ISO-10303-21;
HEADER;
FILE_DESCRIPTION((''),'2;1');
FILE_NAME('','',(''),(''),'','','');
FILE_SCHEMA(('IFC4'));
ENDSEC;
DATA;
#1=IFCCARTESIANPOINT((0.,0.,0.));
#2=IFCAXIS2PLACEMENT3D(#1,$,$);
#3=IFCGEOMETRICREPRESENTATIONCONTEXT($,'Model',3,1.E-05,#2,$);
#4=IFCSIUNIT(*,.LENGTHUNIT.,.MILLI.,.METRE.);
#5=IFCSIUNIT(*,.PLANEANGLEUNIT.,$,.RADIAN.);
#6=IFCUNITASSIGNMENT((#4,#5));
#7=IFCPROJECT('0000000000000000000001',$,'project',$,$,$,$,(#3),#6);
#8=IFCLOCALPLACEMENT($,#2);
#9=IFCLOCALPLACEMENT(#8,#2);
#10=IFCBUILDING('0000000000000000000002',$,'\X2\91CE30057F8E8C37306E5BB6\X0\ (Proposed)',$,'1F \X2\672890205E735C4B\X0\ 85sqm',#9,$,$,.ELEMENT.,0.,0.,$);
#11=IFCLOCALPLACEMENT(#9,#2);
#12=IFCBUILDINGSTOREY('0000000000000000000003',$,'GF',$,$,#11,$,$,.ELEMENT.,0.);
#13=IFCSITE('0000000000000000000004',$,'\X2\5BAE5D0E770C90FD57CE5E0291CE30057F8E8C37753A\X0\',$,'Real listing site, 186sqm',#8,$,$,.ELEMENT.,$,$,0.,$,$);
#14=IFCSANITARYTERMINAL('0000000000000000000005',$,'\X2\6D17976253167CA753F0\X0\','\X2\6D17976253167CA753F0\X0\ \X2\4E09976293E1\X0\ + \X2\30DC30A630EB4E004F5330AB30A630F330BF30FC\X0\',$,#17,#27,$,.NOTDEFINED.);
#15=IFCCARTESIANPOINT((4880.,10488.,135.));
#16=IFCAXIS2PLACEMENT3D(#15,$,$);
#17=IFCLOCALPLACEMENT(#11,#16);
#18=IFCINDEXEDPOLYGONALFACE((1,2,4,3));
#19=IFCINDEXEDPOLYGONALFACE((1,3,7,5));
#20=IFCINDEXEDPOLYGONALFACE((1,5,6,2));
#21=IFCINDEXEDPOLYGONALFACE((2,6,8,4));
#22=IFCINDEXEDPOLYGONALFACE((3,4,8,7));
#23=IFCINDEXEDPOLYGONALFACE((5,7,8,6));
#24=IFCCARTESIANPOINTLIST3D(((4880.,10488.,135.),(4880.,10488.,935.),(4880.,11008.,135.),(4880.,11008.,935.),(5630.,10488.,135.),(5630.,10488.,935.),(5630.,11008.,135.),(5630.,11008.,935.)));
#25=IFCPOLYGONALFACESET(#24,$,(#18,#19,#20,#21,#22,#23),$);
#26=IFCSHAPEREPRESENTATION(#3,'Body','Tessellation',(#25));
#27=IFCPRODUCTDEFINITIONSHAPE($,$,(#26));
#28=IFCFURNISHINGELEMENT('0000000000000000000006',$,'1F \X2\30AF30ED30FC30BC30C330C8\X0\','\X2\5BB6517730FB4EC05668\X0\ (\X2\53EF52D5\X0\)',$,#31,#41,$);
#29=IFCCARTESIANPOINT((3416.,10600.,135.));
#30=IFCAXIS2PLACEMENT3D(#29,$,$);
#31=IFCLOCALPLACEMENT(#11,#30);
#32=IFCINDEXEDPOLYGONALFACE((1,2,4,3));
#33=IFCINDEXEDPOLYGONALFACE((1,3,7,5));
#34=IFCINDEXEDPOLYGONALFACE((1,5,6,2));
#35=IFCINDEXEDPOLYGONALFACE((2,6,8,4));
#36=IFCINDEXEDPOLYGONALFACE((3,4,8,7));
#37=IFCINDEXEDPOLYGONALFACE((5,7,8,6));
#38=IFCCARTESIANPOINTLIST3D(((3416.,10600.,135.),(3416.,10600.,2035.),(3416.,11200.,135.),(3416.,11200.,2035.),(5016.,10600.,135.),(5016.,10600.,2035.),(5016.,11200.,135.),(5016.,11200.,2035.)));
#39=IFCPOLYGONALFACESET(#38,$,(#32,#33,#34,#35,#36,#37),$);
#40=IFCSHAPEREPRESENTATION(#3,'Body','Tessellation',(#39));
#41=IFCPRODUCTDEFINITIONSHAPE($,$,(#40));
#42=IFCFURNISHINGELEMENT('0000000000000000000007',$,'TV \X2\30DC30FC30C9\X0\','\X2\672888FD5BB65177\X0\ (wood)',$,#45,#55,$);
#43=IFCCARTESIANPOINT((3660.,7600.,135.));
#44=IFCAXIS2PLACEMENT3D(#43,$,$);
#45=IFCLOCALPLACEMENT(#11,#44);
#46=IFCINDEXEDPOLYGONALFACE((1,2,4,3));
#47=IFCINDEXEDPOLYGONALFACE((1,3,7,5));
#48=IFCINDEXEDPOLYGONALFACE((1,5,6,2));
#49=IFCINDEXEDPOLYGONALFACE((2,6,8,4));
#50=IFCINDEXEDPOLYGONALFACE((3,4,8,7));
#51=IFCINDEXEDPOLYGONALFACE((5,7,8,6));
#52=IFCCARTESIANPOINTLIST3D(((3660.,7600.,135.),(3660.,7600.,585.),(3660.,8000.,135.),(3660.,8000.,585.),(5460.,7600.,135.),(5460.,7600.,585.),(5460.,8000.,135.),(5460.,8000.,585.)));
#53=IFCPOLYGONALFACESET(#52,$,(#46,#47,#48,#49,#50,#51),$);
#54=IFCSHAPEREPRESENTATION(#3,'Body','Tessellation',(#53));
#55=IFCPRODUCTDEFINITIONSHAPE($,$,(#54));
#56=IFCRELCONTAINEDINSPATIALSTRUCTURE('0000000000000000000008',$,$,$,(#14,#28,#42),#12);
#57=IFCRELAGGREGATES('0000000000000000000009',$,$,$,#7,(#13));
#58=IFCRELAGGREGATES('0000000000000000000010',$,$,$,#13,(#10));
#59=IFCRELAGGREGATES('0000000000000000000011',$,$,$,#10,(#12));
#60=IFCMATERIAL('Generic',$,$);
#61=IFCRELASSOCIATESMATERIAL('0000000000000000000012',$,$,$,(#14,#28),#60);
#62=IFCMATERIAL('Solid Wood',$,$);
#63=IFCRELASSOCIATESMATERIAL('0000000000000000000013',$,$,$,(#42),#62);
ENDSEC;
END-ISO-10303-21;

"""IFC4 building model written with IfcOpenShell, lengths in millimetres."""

from ifc_helpers import new_model, si_unit, frame, frame_2d, origin, place, context, project, spatial, rectangle, extrude, material, element, save


model = new_model("IFC4")

# Units and contexts
model_context = context("Model", 3, precision=1e-05, world=origin())
ifc_project = project(units=[si_unit("LENGTHUNIT", "METRE", prefix="MILLI"), si_unit("PLANEANGLEUNIT", "RADIAN")], contexts=[model_context])

# Site, building, storey
site_placement = place(None, origin())
site = spatial("IfcSite", under=ifc_project, at=site_placement, Name="宮崎県都城市野々美谷町", ObjectType="Real listing site, 186sqm", CompositionType="ELEMENT", RefElevation=0.0)
building_placement = place(site_placement, origin())
building = spatial("IfcBuilding", under=site, at=building_placement, Name="野々美谷の家 (Proposed)", ObjectType="1F 木造平屋 85sqm", CompositionType="ELEMENT", ElevationOfRefHeight=0.0, ElevationOfTerrain=0.0)
storey_placement = place(building_placement, origin())
storey = spatial("IfcBuildingStorey", under=building, at=storey_placement, Name="GF", CompositionType="ELEMENT", Elevation=0.0)

# Shared definitions
ifc_material_1 = material(Name="Solid Wood")

# Shared definitions
ifc_material_2 = material(Name="Generic")

# Sanitary terminal
sanitary_terminal_1_placement = place(storey_placement, frame((4880.0, 10488.0, 135.0)))
element("IfcSanitaryTerminal", 1, at=sanitary_terminal_1_placement, inside=storey, material=ifc_material_2, Name="洗面化粧台", Description="洗面化粧台 三面鏡 + ボウル一体カウンター", PredefinedType="NOTDEFINED", context=model_context, shape_type="SweptSolid", body=[
    extrude(rectangle(XDim=750.0, YDim=520.0, at=frame_2d((375.0, 260.0))), frame((4880.0, 10488.0, 135.0)), (0.0, 0.0, 1.0), 800.0),
])

# Furnishing elements
furnishing_1_placement = place(storey_placement, frame((3416.0, 10600.0, 135.0)))
element("IfcFurnishingElement", 2, at=furnishing_1_placement, inside=storey, material=ifc_material_2, Name="1F クローゼット", Description="家具・什器 (可動)", context=model_context, shape_type="SweptSolid", body=[
    extrude(rectangle(XDim=1600.0, YDim=600.0, at=frame_2d((800.0, 300.0))), frame((3416.0, 10600.0, 135.0)), (0.0, 0.0, 1.0), 1900.0),
])
furnishing_2_placement = place(storey_placement, frame((3660.0, 7600.0, 135.0)))
element("IfcFurnishingElement", 3, at=furnishing_2_placement, inside=storey, material=ifc_material_1, Name="TV ボード", Description="木製家具 (wood)", context=model_context, shape_type="SweptSolid", body=[
    extrude(rectangle(XDim=1800.0, YDim=400.0, at=frame_2d((900.0, 200.0))), frame((3660.0, 7600.0, 135.0)), (0.0, 0.0, 1.0), 450.0),
])

save(model, "model.ifc")
